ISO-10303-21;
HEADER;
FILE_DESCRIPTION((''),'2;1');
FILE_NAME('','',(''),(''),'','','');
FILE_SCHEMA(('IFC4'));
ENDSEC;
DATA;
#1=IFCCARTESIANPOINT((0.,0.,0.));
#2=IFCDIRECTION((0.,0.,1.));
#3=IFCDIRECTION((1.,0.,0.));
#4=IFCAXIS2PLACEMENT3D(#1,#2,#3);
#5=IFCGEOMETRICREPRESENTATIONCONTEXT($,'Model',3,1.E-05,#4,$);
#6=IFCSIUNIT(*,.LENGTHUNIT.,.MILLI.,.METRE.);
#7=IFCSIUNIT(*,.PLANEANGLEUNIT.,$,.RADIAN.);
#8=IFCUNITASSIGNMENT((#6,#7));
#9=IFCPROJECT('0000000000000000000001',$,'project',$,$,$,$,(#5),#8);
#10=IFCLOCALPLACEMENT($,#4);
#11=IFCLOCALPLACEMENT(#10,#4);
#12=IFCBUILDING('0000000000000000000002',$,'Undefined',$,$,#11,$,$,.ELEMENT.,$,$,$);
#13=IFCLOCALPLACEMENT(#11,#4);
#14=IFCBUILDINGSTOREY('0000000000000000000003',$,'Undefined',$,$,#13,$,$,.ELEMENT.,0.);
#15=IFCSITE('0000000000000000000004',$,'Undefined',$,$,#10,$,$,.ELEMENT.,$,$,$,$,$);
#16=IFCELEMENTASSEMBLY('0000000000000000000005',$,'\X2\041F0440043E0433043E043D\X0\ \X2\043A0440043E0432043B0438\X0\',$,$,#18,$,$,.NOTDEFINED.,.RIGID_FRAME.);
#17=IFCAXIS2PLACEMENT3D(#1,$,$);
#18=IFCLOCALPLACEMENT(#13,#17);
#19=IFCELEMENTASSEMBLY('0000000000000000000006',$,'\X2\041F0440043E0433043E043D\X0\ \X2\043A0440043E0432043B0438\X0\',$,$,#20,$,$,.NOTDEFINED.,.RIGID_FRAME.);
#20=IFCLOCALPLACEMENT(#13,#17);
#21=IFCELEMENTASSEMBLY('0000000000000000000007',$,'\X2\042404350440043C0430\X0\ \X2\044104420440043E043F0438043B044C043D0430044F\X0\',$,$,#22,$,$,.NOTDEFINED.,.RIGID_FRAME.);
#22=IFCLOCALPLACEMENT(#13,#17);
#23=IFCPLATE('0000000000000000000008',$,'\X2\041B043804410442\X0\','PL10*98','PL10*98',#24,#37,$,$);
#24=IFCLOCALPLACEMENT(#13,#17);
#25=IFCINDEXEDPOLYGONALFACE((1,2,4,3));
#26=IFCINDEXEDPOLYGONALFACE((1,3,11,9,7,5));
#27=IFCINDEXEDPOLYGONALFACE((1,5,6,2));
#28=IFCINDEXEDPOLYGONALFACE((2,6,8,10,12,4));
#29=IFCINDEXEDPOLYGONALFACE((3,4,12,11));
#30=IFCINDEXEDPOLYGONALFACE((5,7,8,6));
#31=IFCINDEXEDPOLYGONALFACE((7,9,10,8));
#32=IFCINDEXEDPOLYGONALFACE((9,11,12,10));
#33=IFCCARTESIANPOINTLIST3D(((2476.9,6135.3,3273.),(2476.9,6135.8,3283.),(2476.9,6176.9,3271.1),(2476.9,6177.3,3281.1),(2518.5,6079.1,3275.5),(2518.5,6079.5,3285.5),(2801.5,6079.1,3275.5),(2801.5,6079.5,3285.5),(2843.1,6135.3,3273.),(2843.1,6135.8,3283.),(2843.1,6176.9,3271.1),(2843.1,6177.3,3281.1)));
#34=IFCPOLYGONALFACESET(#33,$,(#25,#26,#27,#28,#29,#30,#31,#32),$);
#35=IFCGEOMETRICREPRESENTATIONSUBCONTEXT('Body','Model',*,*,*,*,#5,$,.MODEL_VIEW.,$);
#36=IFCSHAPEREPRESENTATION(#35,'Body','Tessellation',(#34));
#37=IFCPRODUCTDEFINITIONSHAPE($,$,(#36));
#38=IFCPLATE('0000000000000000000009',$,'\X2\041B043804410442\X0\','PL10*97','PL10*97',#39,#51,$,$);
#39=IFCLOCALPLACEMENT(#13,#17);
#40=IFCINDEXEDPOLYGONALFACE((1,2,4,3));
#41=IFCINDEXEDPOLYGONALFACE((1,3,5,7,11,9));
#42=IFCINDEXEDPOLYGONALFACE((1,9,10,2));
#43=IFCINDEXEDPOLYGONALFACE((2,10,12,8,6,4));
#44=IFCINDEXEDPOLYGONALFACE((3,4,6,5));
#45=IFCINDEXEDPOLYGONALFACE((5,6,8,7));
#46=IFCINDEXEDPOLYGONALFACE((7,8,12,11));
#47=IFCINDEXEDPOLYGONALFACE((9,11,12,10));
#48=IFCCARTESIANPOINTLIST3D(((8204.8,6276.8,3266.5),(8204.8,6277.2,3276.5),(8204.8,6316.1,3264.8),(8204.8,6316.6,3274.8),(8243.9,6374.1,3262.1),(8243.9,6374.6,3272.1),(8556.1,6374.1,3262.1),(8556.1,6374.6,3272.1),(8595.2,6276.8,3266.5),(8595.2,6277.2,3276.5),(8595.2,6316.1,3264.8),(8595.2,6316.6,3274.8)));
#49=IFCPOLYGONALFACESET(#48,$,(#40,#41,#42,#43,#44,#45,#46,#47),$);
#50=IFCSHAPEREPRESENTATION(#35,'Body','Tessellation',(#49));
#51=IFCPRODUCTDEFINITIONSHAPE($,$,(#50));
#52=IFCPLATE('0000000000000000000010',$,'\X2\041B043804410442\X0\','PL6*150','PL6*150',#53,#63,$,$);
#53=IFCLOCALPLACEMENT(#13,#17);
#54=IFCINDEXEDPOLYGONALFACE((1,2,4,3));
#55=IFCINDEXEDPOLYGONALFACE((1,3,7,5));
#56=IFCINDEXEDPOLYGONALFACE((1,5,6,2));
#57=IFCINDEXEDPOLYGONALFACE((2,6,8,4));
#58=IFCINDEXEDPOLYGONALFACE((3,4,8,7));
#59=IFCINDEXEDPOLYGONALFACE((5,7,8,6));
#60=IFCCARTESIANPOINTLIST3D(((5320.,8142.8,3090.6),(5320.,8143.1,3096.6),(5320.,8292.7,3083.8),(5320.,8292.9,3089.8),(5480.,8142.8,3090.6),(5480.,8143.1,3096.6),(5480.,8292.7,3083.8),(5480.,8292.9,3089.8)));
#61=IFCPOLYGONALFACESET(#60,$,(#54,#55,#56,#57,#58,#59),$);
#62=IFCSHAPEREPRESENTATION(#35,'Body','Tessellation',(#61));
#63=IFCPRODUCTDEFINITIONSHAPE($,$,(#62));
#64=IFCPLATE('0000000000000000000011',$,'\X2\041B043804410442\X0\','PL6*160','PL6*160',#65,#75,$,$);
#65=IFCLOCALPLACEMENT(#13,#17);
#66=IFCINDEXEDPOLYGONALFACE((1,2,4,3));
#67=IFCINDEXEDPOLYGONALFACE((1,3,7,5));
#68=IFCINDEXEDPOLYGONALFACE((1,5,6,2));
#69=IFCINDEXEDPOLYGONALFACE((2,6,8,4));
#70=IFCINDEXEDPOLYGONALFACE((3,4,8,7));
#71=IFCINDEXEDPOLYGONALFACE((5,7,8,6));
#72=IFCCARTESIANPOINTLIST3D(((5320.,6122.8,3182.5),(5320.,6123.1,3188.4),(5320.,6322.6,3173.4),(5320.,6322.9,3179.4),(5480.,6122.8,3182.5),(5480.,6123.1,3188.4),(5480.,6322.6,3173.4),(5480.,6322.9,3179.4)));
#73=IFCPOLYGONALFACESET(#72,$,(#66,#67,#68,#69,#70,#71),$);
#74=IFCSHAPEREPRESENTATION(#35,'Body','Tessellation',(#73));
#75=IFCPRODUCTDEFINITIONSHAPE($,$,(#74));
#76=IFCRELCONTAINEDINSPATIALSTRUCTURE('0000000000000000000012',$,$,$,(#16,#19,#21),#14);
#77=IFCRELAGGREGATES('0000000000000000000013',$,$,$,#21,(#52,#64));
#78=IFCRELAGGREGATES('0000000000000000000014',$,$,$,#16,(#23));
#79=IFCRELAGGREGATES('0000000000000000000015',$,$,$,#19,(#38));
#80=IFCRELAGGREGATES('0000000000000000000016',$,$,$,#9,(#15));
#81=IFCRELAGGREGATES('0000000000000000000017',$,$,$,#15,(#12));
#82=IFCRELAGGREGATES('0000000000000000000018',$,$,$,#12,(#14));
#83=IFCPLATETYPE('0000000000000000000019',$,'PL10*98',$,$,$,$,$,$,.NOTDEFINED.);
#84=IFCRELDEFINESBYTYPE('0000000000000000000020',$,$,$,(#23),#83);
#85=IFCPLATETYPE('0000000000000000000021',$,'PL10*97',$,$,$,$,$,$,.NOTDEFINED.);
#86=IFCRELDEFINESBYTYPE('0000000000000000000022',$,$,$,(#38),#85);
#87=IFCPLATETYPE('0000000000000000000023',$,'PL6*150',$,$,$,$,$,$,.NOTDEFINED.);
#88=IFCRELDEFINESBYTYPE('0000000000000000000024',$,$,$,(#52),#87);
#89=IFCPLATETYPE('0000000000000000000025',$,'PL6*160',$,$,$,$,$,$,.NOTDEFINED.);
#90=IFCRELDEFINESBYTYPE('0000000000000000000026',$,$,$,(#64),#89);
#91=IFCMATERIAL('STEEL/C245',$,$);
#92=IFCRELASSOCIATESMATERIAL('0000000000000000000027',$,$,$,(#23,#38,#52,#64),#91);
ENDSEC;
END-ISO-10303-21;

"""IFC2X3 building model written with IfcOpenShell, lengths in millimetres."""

from ifc_helpers import new_model, si_unit, frame, origin_with_axes, place, context, subcontext, project, spatial, polyline, outline, extrude, material, type_object, element, aggregate, save


model = new_model("IFC2X3")

# Units and contexts
model_context = context("Model", 3, precision=1e-05, world=origin_with_axes())
body_context = subcontext(model_context, "Body", "Model", "MODEL_VIEW")
ifc_project = project(units=[si_unit("LENGTHUNIT", "METRE", prefix="MILLI"), si_unit("PLANEANGLEUNIT", "RADIAN")], contexts=[model_context])

# Site, building, storey
site_placement = place(None, origin_with_axes())
site = spatial("IfcSite", under=ifc_project, at=site_placement, Name="Undefined", CompositionType="ELEMENT")
building_placement = place(site_placement, origin_with_axes())
building = spatial("IfcBuilding", under=site, at=building_placement, Name="Undefined", CompositionType="ELEMENT")
storey_placement = place(building_placement, origin_with_axes())
storey = spatial("IfcBuildingStorey", under=building, at=storey_placement, Name="Undefined", CompositionType="ELEMENT", Elevation=0.0)

# Shared definitions
ifc_material_1 = material(Name="STEEL/C245")

# Element assemblies
assembly_1_placement = place(storey_placement, origin_with_axes())
assembly_1 = element("IfcElementAssembly", 1, at=assembly_1_placement, inside=storey, Name="Прогон кровли", AssemblyPlace="NOTDEFINED", PredefinedType="RIGID_FRAME")
assembly_2_placement = place(storey_placement, origin_with_axes())
assembly_2 = element("IfcElementAssembly", 2, at=assembly_2_placement, inside=storey, Name="Прогон кровли", AssemblyPlace="NOTDEFINED", PredefinedType="RIGID_FRAME")

# Element assembly
assembly_3_placement = place(storey_placement, origin_with_axes())
assembly_3 = element("IfcElementAssembly", 3, at=assembly_3_placement, inside=storey, Name="Ферма стропильная", AssemblyPlace="NOTDEFINED", PredefinedType="RIGID_FRAME")

# Plates
plate_type_1 = type_object("IfcPlateType", Name="PL10*98", PredefinedType="NOTDEFINED")
plate_1_placement = place(assembly_1_placement, frame((2843.1, 6177.1, 3276.1), z_axis=(0.0, -0.045408, -0.998969), x_axis=(0.0, -0.998969, 0.045408)))
plate_1 = element("IfcPlate", 4, at=plate_1_placement, type_object=plate_type_1, material=ifc_material_1, Name="Лист", Description="PL10*98", ObjectType="PL10*98", context=body_context, shape_type="SweptSolid", body=[
    extrude(outline(polyline([(0.0, 0.0), (41.6, 0.0), (97.9, 41.6), (97.9, 324.6), (41.6, 366.1), (0.0, 366.1), (0.0, 0.0)])), frame((0.0, 0.0, -5.0), z_axis=(0.0, 0.0, 1.0), x_axis=(1.0, 0.0, 0.0)), (0.0, 0.0, 1.0), 10.0),
])
plate_type_2 = type_object("IfcPlateType", Name="PL10*97", PredefinedType="NOTDEFINED")
plate_2_placement = place(assembly_2_placement, frame((8204.8, 6277.0, 3271.5), z_axis=(0.0, -0.045408, -0.998969), x_axis=(0.0, 0.998969, -0.045408)))
plate_2 = element("IfcPlate", 5, at=plate_2_placement, type_object=plate_type_2, material=ifc_material_1, Name="Лист", Description="PL10*97", ObjectType="PL10*97", context=body_context, shape_type="SweptSolid", body=[
    extrude(outline(polyline([(0.0, 0.0), (39.4, 0.0), (97.4, 39.1), (97.4, 351.4), (39.4, 390.5), (0.0, 390.5), (0.0, 0.0)])), frame((0.0, 0.0, -5.0), z_axis=(0.0, 0.0, 1.0), x_axis=(1.0, 0.0, 0.0)), (0.0, 0.0, 1.0), 10.0),
])
plate_type_3 = type_object("IfcPlateType", Name="PL6*150", PredefinedType="NOTDEFINED")
plate_3_placement = place(assembly_3_placement, frame((5480.0, 8142.9, 3093.6), z_axis=(0.0, -0.045408, -0.998969), x_axis=(-1.0, 0.0, 0.0)))
plate_3 = element("IfcPlate", 6, at=plate_3_placement, type_object=plate_type_3, material=ifc_material_1, Name="Лист", Description="PL6*150", ObjectType="PL6*150", context=body_context, shape_type="SweptSolid", body=[
    extrude(outline(polyline([(0.0, 0.0), (160.0, 0.0), (160.0, 150.0), (0.0, 150.0), (0.0, 0.0)])), frame((0.0, 0.0, -3.0), z_axis=(0.0, 0.0, 1.0), x_axis=(1.0, 0.0, 0.0)), (0.0, 0.0, 1.0), 6.0),
])
plate_type_4 = type_object("IfcPlateType", Name="PL6*160", PredefinedType="NOTDEFINED")
plate_4_placement = place(assembly_3_placement, frame((5480.0, 6122.9, 3185.5), z_axis=(0.0, -0.045408, -0.998969), x_axis=(-1.0, 0.0, 0.0)))
plate_4 = element("IfcPlate", 7, at=plate_4_placement, type_object=plate_type_4, material=ifc_material_1, Name="Лист", Description="PL6*160", ObjectType="PL6*160", context=body_context, shape_type="SweptSolid", body=[
    extrude(outline(polyline([(0.0, 0.0), (160.0, 0.0), (160.0, 200.0), (0.0, 200.0), (0.0, 0.0)])), frame((0.0, 0.0, -3.0), z_axis=(0.0, 0.0, 1.0), x_axis=(1.0, 0.0, 0.0)), (0.0, 0.0, 1.0), 6.0),
])
aggregate(assembly_3, [plate_3, plate_4])

aggregate(assembly_1, [plate_1])
aggregate(assembly_2, [plate_2])

save(model, "model.ifc")
